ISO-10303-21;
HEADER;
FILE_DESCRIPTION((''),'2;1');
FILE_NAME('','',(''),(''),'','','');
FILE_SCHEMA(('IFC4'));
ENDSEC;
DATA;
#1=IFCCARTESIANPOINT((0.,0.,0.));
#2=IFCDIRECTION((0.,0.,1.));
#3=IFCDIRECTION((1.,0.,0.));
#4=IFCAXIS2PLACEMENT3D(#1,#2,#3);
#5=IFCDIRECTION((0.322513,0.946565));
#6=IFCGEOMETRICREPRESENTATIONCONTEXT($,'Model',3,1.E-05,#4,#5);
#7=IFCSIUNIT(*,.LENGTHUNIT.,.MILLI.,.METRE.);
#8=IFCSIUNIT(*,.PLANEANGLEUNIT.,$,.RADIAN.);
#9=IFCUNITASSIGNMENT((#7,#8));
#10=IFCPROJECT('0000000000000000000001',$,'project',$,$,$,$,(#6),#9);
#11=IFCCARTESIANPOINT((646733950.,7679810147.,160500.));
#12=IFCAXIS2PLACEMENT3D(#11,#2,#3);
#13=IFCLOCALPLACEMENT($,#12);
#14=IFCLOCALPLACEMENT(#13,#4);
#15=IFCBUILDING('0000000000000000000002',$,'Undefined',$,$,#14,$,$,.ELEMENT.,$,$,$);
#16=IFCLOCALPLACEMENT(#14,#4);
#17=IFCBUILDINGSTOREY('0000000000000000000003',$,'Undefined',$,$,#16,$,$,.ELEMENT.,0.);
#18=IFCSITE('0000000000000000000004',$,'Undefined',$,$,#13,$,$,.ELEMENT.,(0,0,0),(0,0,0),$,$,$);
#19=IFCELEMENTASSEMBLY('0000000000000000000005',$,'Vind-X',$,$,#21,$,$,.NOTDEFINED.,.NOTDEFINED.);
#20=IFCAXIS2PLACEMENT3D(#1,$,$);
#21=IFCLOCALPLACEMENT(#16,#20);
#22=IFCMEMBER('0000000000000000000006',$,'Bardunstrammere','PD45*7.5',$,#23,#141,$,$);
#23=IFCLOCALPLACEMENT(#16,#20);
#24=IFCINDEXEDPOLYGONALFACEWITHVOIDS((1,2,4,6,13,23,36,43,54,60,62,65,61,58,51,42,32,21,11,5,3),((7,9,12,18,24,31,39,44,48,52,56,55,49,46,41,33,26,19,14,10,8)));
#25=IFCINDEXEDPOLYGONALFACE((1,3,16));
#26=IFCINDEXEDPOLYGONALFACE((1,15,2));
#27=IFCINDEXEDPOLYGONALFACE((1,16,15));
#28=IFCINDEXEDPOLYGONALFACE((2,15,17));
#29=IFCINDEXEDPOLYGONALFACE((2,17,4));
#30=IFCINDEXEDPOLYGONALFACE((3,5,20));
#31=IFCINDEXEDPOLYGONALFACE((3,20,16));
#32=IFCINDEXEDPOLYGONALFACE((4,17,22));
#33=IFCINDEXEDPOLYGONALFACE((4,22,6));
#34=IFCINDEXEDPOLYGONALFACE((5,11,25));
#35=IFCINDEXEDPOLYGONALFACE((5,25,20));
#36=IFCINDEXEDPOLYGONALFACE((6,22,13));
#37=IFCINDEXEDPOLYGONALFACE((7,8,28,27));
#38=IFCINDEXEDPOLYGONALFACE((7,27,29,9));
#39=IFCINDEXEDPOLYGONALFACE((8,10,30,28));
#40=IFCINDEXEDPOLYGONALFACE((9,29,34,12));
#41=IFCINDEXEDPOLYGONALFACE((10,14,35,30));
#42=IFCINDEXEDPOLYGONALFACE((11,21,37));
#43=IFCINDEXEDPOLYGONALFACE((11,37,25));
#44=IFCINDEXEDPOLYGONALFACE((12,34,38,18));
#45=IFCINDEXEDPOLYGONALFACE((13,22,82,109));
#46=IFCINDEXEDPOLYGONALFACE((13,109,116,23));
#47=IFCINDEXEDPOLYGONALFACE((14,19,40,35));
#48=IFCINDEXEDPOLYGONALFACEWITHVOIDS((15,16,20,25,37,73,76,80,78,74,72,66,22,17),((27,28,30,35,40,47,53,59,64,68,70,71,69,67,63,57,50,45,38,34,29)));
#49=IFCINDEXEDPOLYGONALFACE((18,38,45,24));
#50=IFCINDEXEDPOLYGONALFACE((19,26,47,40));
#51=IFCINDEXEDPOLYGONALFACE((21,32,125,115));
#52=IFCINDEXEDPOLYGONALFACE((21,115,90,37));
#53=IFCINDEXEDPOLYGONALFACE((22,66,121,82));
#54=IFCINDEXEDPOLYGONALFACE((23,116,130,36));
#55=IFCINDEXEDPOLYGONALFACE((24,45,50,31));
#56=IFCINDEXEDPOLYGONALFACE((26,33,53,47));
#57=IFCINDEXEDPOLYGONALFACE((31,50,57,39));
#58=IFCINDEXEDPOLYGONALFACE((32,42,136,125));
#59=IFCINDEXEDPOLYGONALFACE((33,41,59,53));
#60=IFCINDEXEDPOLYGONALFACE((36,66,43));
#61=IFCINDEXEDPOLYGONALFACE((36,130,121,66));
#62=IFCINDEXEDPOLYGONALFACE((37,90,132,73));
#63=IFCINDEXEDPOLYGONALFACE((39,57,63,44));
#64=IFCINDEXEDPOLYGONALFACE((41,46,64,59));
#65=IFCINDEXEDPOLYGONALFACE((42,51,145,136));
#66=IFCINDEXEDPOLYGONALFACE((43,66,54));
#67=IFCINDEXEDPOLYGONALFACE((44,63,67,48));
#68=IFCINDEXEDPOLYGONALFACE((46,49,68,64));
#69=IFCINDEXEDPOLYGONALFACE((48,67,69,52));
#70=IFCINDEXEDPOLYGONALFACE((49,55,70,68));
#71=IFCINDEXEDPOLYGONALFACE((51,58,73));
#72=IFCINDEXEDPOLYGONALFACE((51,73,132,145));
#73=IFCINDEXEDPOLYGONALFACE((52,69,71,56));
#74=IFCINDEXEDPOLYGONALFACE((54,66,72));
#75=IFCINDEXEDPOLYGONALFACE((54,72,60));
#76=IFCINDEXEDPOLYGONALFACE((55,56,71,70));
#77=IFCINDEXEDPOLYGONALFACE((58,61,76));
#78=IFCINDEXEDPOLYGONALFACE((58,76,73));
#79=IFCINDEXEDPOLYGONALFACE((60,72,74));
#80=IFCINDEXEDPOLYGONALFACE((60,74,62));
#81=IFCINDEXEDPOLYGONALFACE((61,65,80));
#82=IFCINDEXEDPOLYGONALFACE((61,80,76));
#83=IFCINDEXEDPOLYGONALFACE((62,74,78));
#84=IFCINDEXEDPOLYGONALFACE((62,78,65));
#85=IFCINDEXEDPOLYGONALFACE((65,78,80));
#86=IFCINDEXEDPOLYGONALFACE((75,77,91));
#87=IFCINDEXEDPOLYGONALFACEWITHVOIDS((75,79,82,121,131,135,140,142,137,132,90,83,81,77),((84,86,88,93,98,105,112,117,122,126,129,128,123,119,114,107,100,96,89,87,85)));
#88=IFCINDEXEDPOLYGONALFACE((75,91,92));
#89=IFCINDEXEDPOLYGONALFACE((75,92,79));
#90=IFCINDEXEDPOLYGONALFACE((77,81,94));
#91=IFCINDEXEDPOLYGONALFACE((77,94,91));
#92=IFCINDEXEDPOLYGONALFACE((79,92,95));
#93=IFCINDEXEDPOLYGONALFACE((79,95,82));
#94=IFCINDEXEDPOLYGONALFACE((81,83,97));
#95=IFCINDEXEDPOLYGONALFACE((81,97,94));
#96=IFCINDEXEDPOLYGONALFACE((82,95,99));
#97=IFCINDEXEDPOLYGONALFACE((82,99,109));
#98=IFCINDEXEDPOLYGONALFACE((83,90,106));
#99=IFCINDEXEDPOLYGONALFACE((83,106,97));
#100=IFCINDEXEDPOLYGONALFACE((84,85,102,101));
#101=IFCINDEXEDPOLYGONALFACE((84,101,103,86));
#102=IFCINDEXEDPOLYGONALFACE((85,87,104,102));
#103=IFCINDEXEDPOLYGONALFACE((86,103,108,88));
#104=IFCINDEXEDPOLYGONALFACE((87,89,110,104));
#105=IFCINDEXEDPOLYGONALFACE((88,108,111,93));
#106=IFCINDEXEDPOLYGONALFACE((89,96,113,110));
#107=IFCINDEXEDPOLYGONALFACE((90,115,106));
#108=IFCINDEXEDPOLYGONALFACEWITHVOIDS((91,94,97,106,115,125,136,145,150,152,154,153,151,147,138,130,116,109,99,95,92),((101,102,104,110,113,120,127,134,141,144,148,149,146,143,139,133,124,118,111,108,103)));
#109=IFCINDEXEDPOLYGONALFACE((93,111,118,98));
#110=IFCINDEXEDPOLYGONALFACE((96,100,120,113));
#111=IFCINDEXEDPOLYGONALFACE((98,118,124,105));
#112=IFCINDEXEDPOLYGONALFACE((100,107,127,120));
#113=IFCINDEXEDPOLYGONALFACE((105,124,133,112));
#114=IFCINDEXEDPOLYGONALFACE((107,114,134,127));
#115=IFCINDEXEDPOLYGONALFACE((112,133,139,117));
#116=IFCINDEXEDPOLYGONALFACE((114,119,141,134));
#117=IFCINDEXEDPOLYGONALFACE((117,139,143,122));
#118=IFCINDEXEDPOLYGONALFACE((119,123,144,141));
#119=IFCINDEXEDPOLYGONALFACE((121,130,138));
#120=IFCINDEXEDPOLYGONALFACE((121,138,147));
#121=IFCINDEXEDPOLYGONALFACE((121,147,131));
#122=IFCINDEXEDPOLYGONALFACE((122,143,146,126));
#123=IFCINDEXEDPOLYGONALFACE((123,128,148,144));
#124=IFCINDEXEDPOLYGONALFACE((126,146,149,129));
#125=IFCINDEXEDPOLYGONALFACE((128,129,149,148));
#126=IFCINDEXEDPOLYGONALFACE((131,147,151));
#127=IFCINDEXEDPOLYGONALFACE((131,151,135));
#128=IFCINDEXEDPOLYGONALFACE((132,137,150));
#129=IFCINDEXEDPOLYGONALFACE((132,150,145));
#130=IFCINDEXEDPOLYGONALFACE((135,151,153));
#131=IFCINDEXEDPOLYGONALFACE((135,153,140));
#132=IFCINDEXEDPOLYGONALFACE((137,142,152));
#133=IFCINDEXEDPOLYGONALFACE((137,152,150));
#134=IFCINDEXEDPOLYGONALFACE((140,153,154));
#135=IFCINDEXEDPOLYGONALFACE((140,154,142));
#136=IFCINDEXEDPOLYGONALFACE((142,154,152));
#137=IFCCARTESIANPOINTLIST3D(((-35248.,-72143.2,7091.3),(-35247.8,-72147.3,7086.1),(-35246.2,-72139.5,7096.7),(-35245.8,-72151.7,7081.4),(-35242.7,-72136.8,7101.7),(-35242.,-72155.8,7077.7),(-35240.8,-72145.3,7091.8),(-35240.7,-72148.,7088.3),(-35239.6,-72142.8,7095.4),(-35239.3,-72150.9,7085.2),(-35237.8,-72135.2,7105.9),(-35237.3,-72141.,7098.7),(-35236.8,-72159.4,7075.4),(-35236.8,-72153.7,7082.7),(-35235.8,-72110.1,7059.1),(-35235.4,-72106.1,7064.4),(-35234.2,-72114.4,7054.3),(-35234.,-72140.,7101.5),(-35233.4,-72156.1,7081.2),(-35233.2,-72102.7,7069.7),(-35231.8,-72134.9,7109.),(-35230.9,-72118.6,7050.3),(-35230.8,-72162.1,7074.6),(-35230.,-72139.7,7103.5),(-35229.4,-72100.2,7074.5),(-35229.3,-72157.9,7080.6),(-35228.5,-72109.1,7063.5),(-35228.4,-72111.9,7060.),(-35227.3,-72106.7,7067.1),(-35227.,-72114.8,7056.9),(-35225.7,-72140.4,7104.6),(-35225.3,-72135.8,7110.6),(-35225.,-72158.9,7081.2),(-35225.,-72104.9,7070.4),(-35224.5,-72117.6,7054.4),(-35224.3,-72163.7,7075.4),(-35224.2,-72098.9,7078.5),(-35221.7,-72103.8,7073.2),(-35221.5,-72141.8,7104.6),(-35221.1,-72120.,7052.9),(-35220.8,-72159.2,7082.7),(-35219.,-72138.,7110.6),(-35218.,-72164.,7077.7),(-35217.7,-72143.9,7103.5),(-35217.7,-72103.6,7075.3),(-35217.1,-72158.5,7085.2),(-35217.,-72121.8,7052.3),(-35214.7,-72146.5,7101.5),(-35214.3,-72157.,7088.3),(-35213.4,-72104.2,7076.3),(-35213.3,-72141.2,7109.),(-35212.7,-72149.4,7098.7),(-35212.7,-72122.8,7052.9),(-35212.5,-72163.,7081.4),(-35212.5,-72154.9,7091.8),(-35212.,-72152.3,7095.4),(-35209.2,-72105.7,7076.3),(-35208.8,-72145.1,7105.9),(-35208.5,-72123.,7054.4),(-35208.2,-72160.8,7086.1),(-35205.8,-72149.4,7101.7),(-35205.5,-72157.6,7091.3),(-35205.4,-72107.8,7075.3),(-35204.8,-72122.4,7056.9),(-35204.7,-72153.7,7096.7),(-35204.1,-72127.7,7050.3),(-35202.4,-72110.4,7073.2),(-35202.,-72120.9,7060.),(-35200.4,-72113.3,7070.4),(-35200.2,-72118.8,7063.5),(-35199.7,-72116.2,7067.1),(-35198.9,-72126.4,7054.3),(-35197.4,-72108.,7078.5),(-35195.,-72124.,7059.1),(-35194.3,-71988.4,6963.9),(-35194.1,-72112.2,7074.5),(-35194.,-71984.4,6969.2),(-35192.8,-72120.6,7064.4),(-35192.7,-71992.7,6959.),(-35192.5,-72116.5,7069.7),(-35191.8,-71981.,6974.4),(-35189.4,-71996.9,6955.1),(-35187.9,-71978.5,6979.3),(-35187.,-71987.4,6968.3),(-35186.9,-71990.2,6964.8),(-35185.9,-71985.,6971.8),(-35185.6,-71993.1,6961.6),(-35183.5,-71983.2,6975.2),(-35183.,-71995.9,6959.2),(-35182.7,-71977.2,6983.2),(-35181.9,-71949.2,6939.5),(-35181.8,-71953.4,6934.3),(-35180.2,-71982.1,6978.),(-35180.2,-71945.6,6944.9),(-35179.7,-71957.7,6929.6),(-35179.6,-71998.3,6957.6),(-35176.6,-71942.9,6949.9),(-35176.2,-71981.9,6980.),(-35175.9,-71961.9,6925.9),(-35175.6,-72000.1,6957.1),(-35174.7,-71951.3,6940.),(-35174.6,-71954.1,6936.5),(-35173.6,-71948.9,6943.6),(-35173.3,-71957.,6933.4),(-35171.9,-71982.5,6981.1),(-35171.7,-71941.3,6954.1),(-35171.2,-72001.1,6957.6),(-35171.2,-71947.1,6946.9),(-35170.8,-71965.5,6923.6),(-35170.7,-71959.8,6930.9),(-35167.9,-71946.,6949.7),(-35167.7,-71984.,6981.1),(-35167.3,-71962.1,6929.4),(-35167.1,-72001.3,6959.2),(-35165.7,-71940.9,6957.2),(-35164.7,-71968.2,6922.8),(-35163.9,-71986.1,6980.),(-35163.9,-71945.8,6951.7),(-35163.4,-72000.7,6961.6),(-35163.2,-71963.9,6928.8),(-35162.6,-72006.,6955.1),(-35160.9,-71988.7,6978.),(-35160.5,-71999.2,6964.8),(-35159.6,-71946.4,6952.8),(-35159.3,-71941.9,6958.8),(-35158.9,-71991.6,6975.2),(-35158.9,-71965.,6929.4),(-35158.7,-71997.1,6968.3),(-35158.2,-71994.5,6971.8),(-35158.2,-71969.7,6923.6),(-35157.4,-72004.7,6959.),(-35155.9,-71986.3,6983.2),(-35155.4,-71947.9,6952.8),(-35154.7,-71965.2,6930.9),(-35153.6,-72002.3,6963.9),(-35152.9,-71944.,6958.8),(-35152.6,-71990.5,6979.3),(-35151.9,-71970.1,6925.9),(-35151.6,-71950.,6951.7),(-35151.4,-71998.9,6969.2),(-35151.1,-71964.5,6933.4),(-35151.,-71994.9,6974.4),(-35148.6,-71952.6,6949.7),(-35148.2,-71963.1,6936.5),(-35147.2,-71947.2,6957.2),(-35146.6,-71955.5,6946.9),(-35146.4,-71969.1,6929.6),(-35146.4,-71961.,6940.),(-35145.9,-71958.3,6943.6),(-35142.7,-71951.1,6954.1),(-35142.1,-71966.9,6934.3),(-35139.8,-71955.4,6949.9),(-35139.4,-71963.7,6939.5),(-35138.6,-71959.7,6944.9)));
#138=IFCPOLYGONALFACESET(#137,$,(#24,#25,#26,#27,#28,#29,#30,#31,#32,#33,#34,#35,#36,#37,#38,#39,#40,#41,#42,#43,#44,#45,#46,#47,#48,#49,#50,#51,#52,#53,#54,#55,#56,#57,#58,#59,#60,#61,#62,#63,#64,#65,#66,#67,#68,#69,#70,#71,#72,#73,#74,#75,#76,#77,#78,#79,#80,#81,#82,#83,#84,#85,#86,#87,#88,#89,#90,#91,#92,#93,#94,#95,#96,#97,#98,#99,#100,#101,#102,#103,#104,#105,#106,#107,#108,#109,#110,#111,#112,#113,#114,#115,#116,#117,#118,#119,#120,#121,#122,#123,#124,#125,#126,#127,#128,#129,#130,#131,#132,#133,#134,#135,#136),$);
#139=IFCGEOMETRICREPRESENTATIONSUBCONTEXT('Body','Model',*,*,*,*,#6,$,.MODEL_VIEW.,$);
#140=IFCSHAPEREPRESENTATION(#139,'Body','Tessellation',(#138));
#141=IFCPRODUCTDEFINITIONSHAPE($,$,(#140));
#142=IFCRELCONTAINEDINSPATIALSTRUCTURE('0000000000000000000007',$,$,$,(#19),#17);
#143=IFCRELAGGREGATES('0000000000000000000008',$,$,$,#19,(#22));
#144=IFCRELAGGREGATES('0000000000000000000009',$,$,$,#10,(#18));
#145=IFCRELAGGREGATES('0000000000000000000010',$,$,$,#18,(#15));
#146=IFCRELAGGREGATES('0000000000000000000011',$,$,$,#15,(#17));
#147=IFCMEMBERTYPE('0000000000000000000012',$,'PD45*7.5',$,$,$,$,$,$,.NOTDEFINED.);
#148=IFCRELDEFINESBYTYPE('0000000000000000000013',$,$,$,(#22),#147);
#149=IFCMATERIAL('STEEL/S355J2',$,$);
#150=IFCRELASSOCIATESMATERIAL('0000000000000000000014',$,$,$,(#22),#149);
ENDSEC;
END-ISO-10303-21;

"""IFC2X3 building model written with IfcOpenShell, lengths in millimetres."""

from ifc_helpers import new_model, si_unit, direction, frame, origin_with_axes, origin_2d_with_axis, place, context, subcontext, project, spatial, rectangle, hollow_circle, extrude, boolean, material, type_object, element, aggregate, save


model = new_model("IFC2X3")

# Units and contexts
model_context = context("Model", 3, precision=1e-05, world=origin_with_axes(), true_north=direction((0.322513, 0.946565)))
body_context = subcontext(model_context, "Body", "Model", "MODEL_VIEW")
ifc_project = project(units=[si_unit("LENGTHUNIT", "METRE", prefix="MILLI"), si_unit("PLANEANGLEUNIT", "RADIAN")], contexts=[model_context])

# Site, building, storey
site_placement = place(None, frame((646733950.0, 7679810147.0, 160500.0), z_axis=(0.0, 0.0, 1.0), x_axis=(1.0, 0.0, 0.0)))
site = spatial("IfcSite", under=ifc_project, at=site_placement, Name="Undefined", CompositionType="ELEMENT", RefLatitude=(0, 0, 0), RefLongitude=(0, 0, 0))
building_placement = place(site_placement, origin_with_axes())
building = spatial("IfcBuilding", under=site, at=building_placement, Name="Undefined", CompositionType="ELEMENT")
storey_placement = place(building_placement, origin_with_axes())
storey = spatial("IfcBuildingStorey", under=building, at=storey_placement, Name="Undefined", CompositionType="ELEMENT", Elevation=0.0)

# Element assembly
assembly_1_placement = place(storey_placement, origin_with_axes())
assembly_1 = element("IfcElementAssembly", 1, at=assembly_1_placement, inside=storey, Name="Vind-X", AssemblyPlace="NOTDEFINED", PredefinedType="NOTDEFINED")
ifc_material_1 = material(Name="STEEL/S355J2")

# Member
member_type_1 = type_object("IfcMemberType", Name="PD45*7.5", PredefinedType="NOTDEFINED")
member_1_placement = place(assembly_1_placement, frame((-35226.4, -72149.4, 7092.7), z_axis=(0.946565, -0.322513, 0.0), x_axis=(0.259145, 0.760583, -0.595279)))
member_1 = element("IfcMember", 2, at=member_1_placement, type_object=member_type_1, material=ifc_material_1, Name="Bardunstrammere", Description="PD45*7.5", context=body_context, shape_type="CSG", body=[
    boolean("DIFFERENCE", extrude(hollow_circle(Radius=22.5, WallThickness=7.5, at=origin_2d_with_axis()), frame((255.0, 0.0, 0.0), z_axis=(-1.0, 0.0, 0.0), x_axis=(0.0, -1.0, 0.0)), (0.0, 0.0, 1.0), 255.0), extrude(rectangle(XDim=35.0, YDim=90.0, at=origin_2d_with_axis()), frame((207.5, 0.0, 0.0), z_axis=(-1.0, 0.0, 0.0), x_axis=(0.0, -1.0, 0.0)), (0.0, 0.0, 1.0), 160.0)),
])

aggregate(assembly_1, [member_1])

save(model, "model.ifc")
